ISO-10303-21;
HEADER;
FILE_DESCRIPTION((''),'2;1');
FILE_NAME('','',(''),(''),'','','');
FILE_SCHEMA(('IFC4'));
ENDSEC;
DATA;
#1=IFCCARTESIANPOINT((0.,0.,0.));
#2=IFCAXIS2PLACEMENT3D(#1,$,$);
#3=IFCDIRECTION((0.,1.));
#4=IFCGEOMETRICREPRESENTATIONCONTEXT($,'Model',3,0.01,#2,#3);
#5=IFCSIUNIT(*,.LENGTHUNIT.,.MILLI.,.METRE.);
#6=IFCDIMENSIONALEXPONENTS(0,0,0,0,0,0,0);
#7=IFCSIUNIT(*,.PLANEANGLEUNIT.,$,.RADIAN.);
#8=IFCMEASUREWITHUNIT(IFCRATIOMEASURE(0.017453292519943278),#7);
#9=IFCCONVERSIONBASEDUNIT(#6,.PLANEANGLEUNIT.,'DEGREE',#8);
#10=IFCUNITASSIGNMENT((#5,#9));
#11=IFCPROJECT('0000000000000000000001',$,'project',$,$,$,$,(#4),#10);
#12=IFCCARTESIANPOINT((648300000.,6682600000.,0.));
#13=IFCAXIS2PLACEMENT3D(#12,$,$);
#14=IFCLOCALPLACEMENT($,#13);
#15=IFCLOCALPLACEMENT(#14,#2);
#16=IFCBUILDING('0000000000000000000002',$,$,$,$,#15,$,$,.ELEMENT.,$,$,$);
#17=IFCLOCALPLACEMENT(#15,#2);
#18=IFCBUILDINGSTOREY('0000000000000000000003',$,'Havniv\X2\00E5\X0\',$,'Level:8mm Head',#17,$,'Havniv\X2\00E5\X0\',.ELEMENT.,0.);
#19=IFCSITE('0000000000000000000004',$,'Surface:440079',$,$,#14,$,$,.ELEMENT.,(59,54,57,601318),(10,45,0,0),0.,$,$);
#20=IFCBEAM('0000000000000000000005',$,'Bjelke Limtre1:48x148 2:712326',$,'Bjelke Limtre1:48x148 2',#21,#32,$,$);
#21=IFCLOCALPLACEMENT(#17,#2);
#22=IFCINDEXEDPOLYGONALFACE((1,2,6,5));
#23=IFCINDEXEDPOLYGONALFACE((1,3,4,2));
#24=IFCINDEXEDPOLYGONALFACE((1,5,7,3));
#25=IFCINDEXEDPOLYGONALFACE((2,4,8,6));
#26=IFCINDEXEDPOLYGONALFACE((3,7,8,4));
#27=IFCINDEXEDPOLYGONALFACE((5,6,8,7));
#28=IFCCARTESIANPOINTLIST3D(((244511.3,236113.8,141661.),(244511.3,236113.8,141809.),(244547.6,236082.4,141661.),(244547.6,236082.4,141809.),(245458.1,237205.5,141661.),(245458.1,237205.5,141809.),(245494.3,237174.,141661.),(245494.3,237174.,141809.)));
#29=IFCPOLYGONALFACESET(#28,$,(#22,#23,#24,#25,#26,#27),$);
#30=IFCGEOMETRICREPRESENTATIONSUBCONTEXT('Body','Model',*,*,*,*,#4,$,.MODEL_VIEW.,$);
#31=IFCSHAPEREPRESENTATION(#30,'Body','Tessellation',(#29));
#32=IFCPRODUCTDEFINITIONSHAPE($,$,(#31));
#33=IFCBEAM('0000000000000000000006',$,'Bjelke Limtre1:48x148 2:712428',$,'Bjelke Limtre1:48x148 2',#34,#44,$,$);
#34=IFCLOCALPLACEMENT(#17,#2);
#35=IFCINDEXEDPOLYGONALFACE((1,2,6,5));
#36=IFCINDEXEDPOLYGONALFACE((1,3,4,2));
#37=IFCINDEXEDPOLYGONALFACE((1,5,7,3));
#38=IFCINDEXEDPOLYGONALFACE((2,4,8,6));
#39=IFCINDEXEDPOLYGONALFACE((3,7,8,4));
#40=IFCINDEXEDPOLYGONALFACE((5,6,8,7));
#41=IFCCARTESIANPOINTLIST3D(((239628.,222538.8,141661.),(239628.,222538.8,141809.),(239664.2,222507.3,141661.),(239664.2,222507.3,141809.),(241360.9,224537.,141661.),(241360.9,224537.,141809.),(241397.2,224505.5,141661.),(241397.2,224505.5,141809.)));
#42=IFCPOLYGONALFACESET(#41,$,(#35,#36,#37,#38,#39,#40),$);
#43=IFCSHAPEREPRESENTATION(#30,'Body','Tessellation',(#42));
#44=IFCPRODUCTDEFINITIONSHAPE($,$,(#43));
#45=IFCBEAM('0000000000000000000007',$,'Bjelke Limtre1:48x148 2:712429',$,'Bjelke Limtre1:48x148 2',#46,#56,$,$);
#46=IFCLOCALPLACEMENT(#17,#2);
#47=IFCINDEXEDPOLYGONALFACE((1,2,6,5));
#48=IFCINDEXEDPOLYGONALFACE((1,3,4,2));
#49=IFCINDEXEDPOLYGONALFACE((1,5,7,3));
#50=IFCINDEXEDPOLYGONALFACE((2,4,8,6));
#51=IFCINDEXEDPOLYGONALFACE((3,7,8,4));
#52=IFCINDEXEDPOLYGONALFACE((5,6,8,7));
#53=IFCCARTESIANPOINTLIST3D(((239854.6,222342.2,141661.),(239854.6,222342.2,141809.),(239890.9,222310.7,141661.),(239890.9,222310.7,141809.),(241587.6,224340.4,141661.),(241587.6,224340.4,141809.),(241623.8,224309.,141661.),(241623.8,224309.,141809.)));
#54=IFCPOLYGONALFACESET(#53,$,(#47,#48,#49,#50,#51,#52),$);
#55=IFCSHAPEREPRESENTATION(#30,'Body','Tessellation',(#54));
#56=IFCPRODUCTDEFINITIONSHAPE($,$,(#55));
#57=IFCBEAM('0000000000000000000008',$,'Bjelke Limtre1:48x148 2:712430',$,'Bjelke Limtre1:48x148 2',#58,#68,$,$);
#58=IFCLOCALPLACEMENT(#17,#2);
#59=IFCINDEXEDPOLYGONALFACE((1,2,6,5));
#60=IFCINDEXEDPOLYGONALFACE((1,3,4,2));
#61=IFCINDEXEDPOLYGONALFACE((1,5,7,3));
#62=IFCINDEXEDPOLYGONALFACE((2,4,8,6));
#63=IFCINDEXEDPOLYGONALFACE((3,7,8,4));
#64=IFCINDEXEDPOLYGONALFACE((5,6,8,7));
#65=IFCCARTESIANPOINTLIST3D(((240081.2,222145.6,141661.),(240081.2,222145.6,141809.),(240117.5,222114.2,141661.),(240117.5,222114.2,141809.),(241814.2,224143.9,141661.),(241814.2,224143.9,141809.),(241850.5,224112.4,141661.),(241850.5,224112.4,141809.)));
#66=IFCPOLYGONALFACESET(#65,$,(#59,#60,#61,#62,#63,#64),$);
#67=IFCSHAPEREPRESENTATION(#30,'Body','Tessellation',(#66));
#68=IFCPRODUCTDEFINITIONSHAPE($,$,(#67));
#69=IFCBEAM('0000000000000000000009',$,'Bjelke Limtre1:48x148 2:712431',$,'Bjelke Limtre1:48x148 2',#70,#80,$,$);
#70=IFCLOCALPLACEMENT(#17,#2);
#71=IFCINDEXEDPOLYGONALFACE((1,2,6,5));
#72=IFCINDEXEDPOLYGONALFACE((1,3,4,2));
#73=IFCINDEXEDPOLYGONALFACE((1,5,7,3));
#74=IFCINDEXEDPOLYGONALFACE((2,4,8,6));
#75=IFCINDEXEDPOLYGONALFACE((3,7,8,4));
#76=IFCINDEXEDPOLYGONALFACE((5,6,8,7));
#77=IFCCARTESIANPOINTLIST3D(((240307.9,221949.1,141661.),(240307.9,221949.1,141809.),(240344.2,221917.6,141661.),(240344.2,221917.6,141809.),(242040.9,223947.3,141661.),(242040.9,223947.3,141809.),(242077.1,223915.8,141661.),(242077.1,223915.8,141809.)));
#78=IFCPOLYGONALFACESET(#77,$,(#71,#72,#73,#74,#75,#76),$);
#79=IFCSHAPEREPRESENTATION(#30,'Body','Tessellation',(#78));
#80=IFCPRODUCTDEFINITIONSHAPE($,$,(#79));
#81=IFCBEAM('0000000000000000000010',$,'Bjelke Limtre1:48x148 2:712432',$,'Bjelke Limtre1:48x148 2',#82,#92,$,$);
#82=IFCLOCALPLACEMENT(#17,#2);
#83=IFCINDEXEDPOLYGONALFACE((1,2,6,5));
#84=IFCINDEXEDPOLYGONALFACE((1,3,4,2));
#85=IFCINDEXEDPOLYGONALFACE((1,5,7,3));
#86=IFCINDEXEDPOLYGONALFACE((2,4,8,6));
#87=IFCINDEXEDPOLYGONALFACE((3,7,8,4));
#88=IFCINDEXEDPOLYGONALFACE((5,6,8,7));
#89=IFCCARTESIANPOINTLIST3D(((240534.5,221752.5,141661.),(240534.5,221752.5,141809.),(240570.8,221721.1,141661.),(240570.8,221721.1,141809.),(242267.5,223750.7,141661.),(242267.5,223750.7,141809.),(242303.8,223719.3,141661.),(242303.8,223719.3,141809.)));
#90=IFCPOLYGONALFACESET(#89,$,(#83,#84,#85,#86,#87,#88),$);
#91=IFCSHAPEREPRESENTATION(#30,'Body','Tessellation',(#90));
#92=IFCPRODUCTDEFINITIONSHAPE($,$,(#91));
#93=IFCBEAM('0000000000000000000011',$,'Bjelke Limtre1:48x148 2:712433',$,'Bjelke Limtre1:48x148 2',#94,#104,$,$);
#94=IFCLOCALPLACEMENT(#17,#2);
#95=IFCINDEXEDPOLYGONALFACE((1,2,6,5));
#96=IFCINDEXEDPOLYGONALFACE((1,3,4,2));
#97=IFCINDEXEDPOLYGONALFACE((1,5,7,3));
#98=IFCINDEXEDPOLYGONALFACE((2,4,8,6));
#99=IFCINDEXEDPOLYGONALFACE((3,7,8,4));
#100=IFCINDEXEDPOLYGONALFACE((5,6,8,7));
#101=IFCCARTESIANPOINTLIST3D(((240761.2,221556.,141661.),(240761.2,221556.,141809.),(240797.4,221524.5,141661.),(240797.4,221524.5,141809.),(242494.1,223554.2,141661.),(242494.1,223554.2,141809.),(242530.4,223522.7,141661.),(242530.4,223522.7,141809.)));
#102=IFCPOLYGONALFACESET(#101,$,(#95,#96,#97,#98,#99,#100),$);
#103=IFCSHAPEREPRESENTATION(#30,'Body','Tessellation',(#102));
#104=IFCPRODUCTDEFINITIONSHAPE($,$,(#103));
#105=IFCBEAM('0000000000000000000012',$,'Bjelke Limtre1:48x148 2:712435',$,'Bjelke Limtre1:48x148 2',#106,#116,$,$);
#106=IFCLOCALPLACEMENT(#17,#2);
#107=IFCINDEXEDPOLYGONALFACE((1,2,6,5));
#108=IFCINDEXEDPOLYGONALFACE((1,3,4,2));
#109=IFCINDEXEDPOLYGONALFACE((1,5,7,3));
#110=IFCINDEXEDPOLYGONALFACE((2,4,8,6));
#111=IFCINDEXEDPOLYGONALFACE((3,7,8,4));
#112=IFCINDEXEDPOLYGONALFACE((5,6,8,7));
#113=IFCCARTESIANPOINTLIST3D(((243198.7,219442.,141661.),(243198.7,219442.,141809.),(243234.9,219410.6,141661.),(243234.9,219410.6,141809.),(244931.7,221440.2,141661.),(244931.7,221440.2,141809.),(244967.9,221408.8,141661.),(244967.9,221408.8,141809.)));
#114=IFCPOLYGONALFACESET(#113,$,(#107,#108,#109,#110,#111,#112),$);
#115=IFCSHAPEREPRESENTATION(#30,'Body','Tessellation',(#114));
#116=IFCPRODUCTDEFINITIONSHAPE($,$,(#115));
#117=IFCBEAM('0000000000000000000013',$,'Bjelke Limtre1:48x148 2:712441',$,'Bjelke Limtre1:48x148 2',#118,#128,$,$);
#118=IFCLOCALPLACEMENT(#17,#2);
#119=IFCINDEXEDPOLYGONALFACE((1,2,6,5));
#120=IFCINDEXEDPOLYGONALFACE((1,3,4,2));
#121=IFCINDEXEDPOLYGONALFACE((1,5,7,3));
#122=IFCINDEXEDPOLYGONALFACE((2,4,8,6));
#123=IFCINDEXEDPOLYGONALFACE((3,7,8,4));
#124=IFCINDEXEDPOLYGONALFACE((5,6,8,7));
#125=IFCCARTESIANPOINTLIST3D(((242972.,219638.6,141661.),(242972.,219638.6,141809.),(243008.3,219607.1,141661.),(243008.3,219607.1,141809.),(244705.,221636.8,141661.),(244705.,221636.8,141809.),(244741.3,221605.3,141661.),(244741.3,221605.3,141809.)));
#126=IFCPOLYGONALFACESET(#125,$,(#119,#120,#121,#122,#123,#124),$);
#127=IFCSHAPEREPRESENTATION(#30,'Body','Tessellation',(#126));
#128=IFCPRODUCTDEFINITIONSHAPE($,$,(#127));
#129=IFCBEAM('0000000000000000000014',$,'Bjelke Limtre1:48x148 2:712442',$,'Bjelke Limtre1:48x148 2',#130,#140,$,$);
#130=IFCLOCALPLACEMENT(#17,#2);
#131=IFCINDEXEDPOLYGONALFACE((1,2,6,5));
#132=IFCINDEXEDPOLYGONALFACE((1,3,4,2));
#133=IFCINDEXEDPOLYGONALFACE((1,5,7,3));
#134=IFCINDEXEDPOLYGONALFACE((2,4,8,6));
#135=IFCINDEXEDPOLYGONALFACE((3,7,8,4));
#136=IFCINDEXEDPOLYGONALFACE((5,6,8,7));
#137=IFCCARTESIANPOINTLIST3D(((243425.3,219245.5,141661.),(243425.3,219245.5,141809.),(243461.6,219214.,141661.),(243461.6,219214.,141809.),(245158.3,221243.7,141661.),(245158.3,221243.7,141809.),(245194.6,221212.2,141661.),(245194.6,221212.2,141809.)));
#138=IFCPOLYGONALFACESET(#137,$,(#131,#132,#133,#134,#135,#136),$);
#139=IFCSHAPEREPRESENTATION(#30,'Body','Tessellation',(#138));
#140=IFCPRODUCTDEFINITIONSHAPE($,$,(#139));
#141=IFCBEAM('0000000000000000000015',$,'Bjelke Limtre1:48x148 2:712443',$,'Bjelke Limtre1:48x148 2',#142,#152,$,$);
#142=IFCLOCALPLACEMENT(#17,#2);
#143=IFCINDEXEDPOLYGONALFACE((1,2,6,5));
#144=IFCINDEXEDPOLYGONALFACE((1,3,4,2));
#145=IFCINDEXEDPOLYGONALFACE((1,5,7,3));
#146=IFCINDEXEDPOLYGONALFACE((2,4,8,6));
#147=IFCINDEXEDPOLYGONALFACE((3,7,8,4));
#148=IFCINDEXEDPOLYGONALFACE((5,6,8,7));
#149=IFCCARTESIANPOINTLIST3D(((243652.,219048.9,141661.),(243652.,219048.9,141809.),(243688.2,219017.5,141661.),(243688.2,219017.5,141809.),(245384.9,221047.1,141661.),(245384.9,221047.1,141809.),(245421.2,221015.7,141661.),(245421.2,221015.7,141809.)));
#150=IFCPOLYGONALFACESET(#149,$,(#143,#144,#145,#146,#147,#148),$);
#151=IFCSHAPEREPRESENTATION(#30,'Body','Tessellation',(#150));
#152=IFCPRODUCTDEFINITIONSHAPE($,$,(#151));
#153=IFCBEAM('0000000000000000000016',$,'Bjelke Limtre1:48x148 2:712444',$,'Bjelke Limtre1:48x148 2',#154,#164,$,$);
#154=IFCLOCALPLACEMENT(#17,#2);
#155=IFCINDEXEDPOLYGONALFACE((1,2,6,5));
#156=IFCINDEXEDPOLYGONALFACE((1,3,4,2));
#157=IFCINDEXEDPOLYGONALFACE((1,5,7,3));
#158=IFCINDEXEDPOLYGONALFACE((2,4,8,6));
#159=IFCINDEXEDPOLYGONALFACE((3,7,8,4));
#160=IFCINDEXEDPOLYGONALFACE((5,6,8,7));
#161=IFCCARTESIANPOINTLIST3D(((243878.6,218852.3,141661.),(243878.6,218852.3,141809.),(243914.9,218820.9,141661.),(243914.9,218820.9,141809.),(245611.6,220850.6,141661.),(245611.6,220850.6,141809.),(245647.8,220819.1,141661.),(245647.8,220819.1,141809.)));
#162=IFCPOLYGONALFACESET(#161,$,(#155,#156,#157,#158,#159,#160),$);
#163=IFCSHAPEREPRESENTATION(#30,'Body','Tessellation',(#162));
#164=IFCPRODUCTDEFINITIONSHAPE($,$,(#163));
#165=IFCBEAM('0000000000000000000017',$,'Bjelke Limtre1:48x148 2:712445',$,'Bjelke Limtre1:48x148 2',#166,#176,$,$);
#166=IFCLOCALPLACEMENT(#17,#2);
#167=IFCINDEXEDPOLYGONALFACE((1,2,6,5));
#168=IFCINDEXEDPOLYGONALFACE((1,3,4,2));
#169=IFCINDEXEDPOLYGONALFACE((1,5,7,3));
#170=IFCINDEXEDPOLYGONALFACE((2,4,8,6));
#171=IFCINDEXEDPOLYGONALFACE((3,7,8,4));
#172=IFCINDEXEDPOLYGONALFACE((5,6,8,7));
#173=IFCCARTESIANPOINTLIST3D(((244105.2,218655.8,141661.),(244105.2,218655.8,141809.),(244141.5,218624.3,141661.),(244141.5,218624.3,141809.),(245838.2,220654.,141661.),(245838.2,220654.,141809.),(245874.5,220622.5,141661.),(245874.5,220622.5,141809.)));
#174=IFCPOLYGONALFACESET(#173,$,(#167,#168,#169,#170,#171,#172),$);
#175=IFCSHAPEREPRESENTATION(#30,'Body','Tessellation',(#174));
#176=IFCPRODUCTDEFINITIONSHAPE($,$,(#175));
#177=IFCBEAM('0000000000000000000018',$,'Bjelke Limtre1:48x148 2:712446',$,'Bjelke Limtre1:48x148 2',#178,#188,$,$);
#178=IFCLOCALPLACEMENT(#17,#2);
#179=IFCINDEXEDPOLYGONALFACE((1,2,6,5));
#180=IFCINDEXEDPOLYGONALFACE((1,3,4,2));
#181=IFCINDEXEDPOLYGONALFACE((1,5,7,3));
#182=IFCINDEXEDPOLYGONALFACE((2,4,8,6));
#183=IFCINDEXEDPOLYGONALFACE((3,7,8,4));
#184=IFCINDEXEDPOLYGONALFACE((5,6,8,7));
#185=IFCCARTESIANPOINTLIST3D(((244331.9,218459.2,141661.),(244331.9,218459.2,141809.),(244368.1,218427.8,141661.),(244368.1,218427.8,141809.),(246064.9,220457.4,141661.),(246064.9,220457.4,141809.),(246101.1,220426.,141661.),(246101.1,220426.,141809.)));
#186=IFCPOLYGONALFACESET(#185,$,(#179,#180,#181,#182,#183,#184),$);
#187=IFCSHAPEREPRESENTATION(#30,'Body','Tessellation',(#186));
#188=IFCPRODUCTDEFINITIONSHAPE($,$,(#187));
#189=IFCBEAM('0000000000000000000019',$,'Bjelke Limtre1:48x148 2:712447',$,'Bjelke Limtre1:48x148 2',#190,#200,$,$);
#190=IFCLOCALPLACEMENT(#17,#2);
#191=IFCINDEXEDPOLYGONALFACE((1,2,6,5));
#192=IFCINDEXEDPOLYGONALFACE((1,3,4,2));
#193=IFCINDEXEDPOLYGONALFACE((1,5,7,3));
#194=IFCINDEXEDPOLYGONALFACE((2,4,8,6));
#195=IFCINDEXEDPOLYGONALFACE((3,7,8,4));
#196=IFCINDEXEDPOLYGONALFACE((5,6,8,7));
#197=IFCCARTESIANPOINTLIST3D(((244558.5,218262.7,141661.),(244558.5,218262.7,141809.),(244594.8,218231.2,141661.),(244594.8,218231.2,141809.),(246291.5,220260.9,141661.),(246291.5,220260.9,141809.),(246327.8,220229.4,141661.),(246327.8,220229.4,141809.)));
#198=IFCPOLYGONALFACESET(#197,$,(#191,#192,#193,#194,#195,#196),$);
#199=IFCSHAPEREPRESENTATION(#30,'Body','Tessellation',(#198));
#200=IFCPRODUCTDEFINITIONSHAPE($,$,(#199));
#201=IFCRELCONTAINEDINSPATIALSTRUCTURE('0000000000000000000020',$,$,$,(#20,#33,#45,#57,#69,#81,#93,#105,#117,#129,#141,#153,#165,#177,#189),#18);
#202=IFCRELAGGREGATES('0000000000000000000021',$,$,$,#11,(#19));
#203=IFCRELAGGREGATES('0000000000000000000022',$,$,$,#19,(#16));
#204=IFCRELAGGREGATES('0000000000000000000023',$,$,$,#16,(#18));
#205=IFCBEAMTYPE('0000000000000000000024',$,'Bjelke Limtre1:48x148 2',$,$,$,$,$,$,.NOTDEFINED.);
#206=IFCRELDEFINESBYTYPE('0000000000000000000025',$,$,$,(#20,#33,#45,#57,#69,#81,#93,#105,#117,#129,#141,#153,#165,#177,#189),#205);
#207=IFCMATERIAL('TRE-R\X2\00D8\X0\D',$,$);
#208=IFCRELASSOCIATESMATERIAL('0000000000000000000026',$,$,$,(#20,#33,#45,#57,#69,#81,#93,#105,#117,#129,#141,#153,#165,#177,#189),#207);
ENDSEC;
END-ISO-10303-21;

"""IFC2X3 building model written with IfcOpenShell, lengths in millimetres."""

from ifc_helpers import new_model, entity, si_unit, converted_unit, direction, frame, frame_2d, origin, origin_2d_with_axis, place, context, subcontext, project, spatial, rectangle, extrude, material, type_object, element, save


model = new_model("IFC2X3")

# Units and contexts
model_context = context("Model", 3, precision=0.01, world=origin(), true_north=direction((0.0, 1.0)))
body_context = subcontext(model_context, "Body", "Model", "MODEL_VIEW")
ifc_project = project(units=[si_unit("LENGTHUNIT", "METRE", prefix="MILLI"), converted_unit("PLANEANGLEUNIT", "DEGREE", entity("IfcRatioMeasure", 0.017453292519943278), si_unit("PLANEANGLEUNIT", "RADIAN"), dimensions=[0, 0, 0, 0, 0, 0, 0])], contexts=[model_context])

# Site, building, storey
site_placement = place(None, frame((648300000.0, 6682600000.0, 0.0)))
site = spatial("IfcSite", under=ifc_project, at=site_placement, Name="Surface:440079", CompositionType="ELEMENT", RefLatitude=(59, 54, 57, 601318), RefLongitude=(10, 45, 0, 0), RefElevation=0.0)
building_placement = place(site_placement, origin())
building = spatial("IfcBuilding", under=site, at=building_placement, CompositionType="ELEMENT")
storey_placement = place(building_placement, origin())
storey = spatial("IfcBuildingStorey", under=building, at=storey_placement, Name="Havnivå", ObjectType="Level:8mm Head", LongName="Havnivå", CompositionType="ELEMENT", Elevation=0.0)

# Beams
ifc_material = material(Name="TRE-RØD")
beam_type = type_object("IfcBeamType", Name="Bjelke Limtre1:48x148 2", PredefinedType="NOTDEFINED")
for number, where, z_axis, x_axis, name in (
    (1, (245476.2, 237189.7, 141809.0), (0.0, 0.0, 1.0), (-0.655187, -0.755467, 0.0), "Bjelke Limtre1:48x148 2:712326"),
):
    element("IfcBeam", number, at=place(storey_placement, frame(where, z_axis=z_axis, x_axis=x_axis)), inside=storey, type_object=beam_type, material=ifc_material, Name=name, ObjectType="Bjelke Limtre1:48x148 2", context=body_context, shape_type="SweptSolid", body=[
        extrude(rectangle(XDim=148.0, YDim=48.0, at=frame_2d((0.0, 0.0), x_axis=(1.0, 0.0))), frame((0.0, 0.0, -74.0), z_axis=(1.0, 0.0, 0.0), x_axis=(0.0, 0.0, -1.0)), (0.0, 0.0, 1.0), 1445.0),
    ])
beam_1_placement = place(storey_placement, frame((241379.1, 224521.2, 141809.0), z_axis=(0.0, 0.0, 1.0), x_axis=(-0.655187, -0.755467, 0.0)))
element("IfcBeam", 2, at=beam_1_placement, inside=storey, type_object=beam_type, material=ifc_material, Name="Bjelke Limtre1:48x148 2:712428", ObjectType="Bjelke Limtre1:48x148 2", context=body_context, shape_type="SweptSolid", body=[
    extrude(rectangle(XDim=148.0, YDim=48.0, at=origin_2d_with_axis()), frame((0.0, 0.0, -74.0), z_axis=(1.0, 0.0, 0.0), x_axis=(0.0, 0.0, -1.0)), (0.0, 0.0, 1.0), 2645.0),
])
beam_2_placement = place(storey_placement, frame((241605.7, 224324.7, 141809.0), z_axis=(0.0, 0.0, 1.0), x_axis=(-0.655187, -0.755467, 0.0)))
element("IfcBeam", 3, at=beam_2_placement, inside=storey, type_object=beam_type, material=ifc_material, Name="Bjelke Limtre1:48x148 2:712429", ObjectType="Bjelke Limtre1:48x148 2", context=body_context, shape_type="SweptSolid", body=[
    extrude(rectangle(XDim=148.0, YDim=48.0, at=frame_2d((0.0, 0.0), x_axis=(1.0, 0.0))), frame((0.0, 0.0, -74.0), z_axis=(1.0, 0.0, 0.0), x_axis=(0.0, 0.0, -1.0)), (0.0, 0.0, 1.0), 2645.0),
])
for number, where, z_axis, x_axis, name in (
    (4, (241832.4, 224128.1, 141809.0), (0.0, 0.0, 1.0), (-0.655187, -0.755467, 0.0), "Bjelke Limtre1:48x148 2:712430"),
    (5, (242059.0, 223931.6, 141809.0), (0.0, 0.0, 1.0), (-0.655187, -0.755467, 0.0), "Bjelke Limtre1:48x148 2:712431"),
):
    element("IfcBeam", number, at=place(storey_placement, frame(where, z_axis=z_axis, x_axis=x_axis)), inside=storey, type_object=beam_type, material=ifc_material, Name=name, ObjectType="Bjelke Limtre1:48x148 2", context=body_context, shape_type="SweptSolid", body=[
        extrude(rectangle(XDim=148.0, YDim=48.0, at=origin_2d_with_axis()), frame((0.0, 0.0, -74.0), z_axis=(1.0, 0.0, 0.0), x_axis=(0.0, 0.0, -1.0)), (0.0, 0.0, 1.0), 2645.0),
    ])
beam_3_placement = place(storey_placement, frame((242285.6, 223735.0, 141809.0), z_axis=(0.0, 0.0, 1.0), x_axis=(-0.655187, -0.755467, 0.0)))
element("IfcBeam", 6, at=beam_3_placement, inside=storey, type_object=beam_type, material=ifc_material, Name="Bjelke Limtre1:48x148 2:712432", ObjectType="Bjelke Limtre1:48x148 2", context=body_context, shape_type="SweptSolid", body=[
    extrude(rectangle(XDim=148.0, YDim=48.0, at=frame_2d((0.0, 0.0), x_axis=(1.0, 0.0))), frame((0.0, 0.0, -74.0), z_axis=(1.0, 0.0, 0.0), x_axis=(0.0, 0.0, -1.0)), (0.0, 0.0, 1.0), 2645.0),
])
for number, where, z_axis, x_axis, name in (
    (7, (242512.3, 223538.5, 141809.0), (0.0, 0.0, 1.0), (-0.655187, -0.755467, 0.0), "Bjelke Limtre1:48x148 2:712433"),
    (8, (244949.8, 221424.5, 141809.0), (0.0, 0.0, 1.0), (-0.655187, -0.755467, 0.0), "Bjelke Limtre1:48x148 2:712435"),
    (9, (244723.1, 221621.1, 141809.0), (0.0, 0.0, 1.0), (-0.655187, -0.755467, 0.0), "Bjelke Limtre1:48x148 2:712441"),
):
    element("IfcBeam", number, at=place(storey_placement, frame(where, z_axis=z_axis, x_axis=x_axis)), inside=storey, type_object=beam_type, material=ifc_material, Name=name, ObjectType="Bjelke Limtre1:48x148 2", context=body_context, shape_type="SweptSolid", body=[
        extrude(rectangle(XDim=148.0, YDim=48.0, at=origin_2d_with_axis()), frame((0.0, 0.0, -74.0), z_axis=(1.0, 0.0, 0.0), x_axis=(0.0, 0.0, -1.0)), (0.0, 0.0, 1.0), 2645.0),
    ])
beam_4_placement = place(storey_placement, frame((245176.4, 221227.9, 141809.0), z_axis=(0.0, 0.0, 1.0), x_axis=(-0.655187, -0.755467, 0.0)))
element("IfcBeam", 10, at=beam_4_placement, inside=storey, type_object=beam_type, material=ifc_material, Name="Bjelke Limtre1:48x148 2:712442", ObjectType="Bjelke Limtre1:48x148 2", context=body_context, shape_type="SweptSolid", body=[
    extrude(rectangle(XDim=148.0, YDim=48.0, at=frame_2d((0.0, 0.0), x_axis=(1.0, 0.0))), frame((0.0, 0.0, -74.0), z_axis=(1.0, 0.0, 0.0), x_axis=(0.0, 0.0, -1.0)), (0.0, 0.0, 1.0), 2645.0),
])
beam_5_placement = place(storey_placement, frame((245403.1, 221031.4, 141809.0), z_axis=(0.0, 0.0, 1.0), x_axis=(-0.655187, -0.755467, 0.0)))
element("IfcBeam", 11, at=beam_5_placement, inside=storey, type_object=beam_type, material=ifc_material, Name="Bjelke Limtre1:48x148 2:712443", ObjectType="Bjelke Limtre1:48x148 2", context=body_context, shape_type="SweptSolid", body=[
    extrude(rectangle(XDim=148.0, YDim=48.0, at=origin_2d_with_axis()), frame((0.0, 0.0, -74.0), z_axis=(1.0, 0.0, 0.0), x_axis=(0.0, 0.0, -1.0)), (0.0, 0.0, 1.0), 2645.0),
])
beam_6_placement = place(storey_placement, frame((245629.7, 220834.8, 141809.0), z_axis=(0.0, 0.0, 1.0), x_axis=(-0.655187, -0.755467, 0.0)))
element("IfcBeam", 12, at=beam_6_placement, inside=storey, type_object=beam_type, material=ifc_material, Name="Bjelke Limtre1:48x148 2:712444", ObjectType="Bjelke Limtre1:48x148 2", context=body_context, shape_type="SweptSolid", body=[
    extrude(rectangle(XDim=148.0, YDim=48.0, at=frame_2d((0.0, 0.0), x_axis=(1.0, 0.0))), frame((0.0, 0.0, -74.0), z_axis=(1.0, 0.0, 0.0), x_axis=(0.0, 0.0, -1.0)), (0.0, 0.0, 1.0), 2645.0),
])
beam_7_placement = place(storey_placement, frame((245856.3, 220638.3, 141809.0), z_axis=(0.0, 0.0, 1.0), x_axis=(-0.655187, -0.755467, 0.0)))
element("IfcBeam", 13, at=beam_7_placement, inside=storey, type_object=beam_type, material=ifc_material, Name="Bjelke Limtre1:48x148 2:712445", ObjectType="Bjelke Limtre1:48x148 2", context=body_context, shape_type="SweptSolid", body=[
    extrude(rectangle(XDim=148.0, YDim=48.0, at=origin_2d_with_axis()), frame((0.0, 0.0, -74.0), z_axis=(1.0, 0.0, 0.0), x_axis=(0.0, 0.0, -1.0)), (0.0, 0.0, 1.0), 2645.0),
])
beam_8_placement = place(storey_placement, frame((246083.0, 220441.7, 141809.0), z_axis=(0.0, 0.0, 1.0), x_axis=(-0.655187, -0.755467, 0.0)))
element("IfcBeam", 14, at=beam_8_placement, inside=storey, type_object=beam_type, material=ifc_material, Name="Bjelke Limtre1:48x148 2:712446", ObjectType="Bjelke Limtre1:48x148 2", context=body_context, shape_type="SweptSolid", body=[
    extrude(rectangle(XDim=148.0, YDim=48.0, at=frame_2d((0.0, 0.0), x_axis=(1.0, 0.0))), frame((0.0, 0.0, -74.0), z_axis=(1.0, 0.0, 0.0), x_axis=(0.0, 0.0, -1.0)), (0.0, 0.0, 1.0), 2645.0),
])
beam_9_placement = place(storey_placement, frame((246309.6, 220245.2, 141809.0), z_axis=(0.0, 0.0, 1.0), x_axis=(-0.655187, -0.755467, 0.0)))
element("IfcBeam", 15, at=beam_9_placement, inside=storey, type_object=beam_type, material=ifc_material, Name="Bjelke Limtre1:48x148 2:712447", ObjectType="Bjelke Limtre1:48x148 2", context=body_context, shape_type="SweptSolid", body=[
    extrude(rectangle(XDim=148.0, YDim=48.0, at=origin_2d_with_axis()), frame((0.0, 0.0, -74.0), z_axis=(1.0, 0.0, 0.0), x_axis=(0.0, 0.0, -1.0)), (0.0, 0.0, 1.0), 2645.0),
])

save(model, "model.ifc")
